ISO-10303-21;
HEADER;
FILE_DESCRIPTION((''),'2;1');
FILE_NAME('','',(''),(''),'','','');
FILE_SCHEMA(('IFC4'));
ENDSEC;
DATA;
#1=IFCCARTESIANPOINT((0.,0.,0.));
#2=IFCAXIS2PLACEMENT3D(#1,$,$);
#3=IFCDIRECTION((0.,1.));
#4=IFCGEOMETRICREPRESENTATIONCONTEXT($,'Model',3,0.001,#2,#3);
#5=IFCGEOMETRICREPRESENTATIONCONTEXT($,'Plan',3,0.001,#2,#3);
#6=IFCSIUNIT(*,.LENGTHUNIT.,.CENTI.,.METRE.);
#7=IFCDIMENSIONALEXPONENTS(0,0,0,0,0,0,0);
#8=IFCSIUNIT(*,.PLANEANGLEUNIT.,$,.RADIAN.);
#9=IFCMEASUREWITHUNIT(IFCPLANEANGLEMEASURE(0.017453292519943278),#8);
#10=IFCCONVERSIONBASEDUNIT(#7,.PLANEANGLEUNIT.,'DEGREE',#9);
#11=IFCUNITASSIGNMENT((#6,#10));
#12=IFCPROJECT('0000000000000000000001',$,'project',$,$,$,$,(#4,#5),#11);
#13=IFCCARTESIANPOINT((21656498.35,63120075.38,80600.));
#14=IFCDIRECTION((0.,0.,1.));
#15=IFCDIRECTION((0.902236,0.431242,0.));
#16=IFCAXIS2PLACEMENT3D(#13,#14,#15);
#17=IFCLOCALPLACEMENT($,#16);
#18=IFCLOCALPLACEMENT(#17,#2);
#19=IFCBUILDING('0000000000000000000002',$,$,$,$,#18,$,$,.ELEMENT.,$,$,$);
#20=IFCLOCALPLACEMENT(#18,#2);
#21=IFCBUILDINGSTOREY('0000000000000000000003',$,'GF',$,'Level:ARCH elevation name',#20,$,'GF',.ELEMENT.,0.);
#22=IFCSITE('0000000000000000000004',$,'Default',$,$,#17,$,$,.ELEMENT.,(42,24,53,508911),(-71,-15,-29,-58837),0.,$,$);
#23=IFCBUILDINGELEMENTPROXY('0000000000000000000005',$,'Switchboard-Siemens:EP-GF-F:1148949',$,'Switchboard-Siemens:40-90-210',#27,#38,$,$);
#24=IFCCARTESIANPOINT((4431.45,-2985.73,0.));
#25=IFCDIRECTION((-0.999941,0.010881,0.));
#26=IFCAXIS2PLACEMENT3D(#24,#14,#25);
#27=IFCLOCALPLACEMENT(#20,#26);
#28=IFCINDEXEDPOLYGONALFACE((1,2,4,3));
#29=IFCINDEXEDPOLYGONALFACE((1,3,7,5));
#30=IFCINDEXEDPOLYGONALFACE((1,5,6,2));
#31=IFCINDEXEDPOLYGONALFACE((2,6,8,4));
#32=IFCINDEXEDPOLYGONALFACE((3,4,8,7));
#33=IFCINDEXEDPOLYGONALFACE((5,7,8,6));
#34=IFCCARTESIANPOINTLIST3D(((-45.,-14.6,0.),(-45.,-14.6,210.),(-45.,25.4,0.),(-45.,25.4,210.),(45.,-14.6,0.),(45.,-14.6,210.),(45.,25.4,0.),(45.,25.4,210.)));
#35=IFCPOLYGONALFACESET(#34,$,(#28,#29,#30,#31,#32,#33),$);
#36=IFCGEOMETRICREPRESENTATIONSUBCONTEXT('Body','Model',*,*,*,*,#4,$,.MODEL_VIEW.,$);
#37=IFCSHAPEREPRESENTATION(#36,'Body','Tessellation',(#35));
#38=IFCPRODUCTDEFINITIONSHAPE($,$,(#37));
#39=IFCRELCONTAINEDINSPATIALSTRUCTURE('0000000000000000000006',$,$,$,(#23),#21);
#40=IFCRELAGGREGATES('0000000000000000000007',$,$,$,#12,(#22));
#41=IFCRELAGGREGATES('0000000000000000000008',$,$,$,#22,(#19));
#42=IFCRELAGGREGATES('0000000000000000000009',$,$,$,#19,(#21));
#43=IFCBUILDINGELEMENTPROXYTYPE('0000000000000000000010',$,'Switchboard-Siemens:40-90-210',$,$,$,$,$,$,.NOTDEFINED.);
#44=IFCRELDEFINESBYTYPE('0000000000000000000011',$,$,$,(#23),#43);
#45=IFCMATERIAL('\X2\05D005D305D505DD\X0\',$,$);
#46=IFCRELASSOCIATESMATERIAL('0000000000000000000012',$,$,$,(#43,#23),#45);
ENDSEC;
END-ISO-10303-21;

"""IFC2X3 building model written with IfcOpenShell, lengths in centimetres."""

from ifc_helpers import new_model, entity, si_unit, converted_unit, direction, frame, origin, origin_2d_with_axis, place, context, subcontext, project, spatial, rectangle, extrude, source, transform, mapped, material, type_object, type_shapes, element, save


model = new_model("IFC2X3")

# Units and contexts
model_context = context("Model", 3, precision=0.001, world=origin(), true_north=direction((0.0, 1.0)))
plan_context = context("Plan", 3, precision=0.001, world=origin(), true_north=direction((0.0, 1.0)))
body_context = subcontext(model_context, "Body", "Model", "MODEL_VIEW")
ifc_project = project(units=[si_unit("LENGTHUNIT", "METRE", prefix="CENTI"), converted_unit("PLANEANGLEUNIT", "DEGREE", entity("IfcPlaneAngleMeasure", 0.017453292519943278), si_unit("PLANEANGLEUNIT", "RADIAN"), dimensions=[0, 0, 0, 0, 0, 0, 0])], contexts=[model_context, plan_context])

# Site, building, storey
site_placement = place(None, frame((21656498.35, 63120075.38, 80600.0), z_axis=(0.0, 0.0, 1.0), x_axis=(0.902236, 0.431242, 0.0)))
site = spatial("IfcSite", under=ifc_project, at=site_placement, Name="Default", CompositionType="ELEMENT", RefLatitude=(42, 24, 53, 508911), RefLongitude=(-71, -15, -29, -58837), RefElevation=0.0)
building_placement = place(site_placement, origin())
building = spatial("IfcBuilding", under=site, at=building_placement, CompositionType="ELEMENT")
storey_placement = place(building_placement, origin())
storey = spatial("IfcBuildingStorey", under=building, at=storey_placement, Name="GF", ObjectType="Level:ARCH elevation name", LongName="GF", CompositionType="ELEMENT", Elevation=0.0)

# Building element proxy
ifc_material_1 = material(Name="אדום")
building_element_proxy_type_1 = type_object("IfcBuildingElementProxyType", Name="Switchboard-Siemens:40-90-210", PredefinedType="NOTDEFINED", material=ifc_material_1)
shared_shape_1 = source(origin(), body_context, "Body", "SweptSolid", [
    extrude(rectangle(XDim=90.0, YDim=40.0, at=origin_2d_with_axis()), frame((0.0, 5.4, 0.0), z_axis=(0.0, 0.0, 1.0), x_axis=(-1.0, 0.0, 0.0)), (0.0, 0.0, 1.0), 210.0),
])
type_shapes(building_element_proxy_type_1, [shared_shape_1])
proxy_1_placement = place(storey_placement, frame((4431.45, -2985.73, 0.0), z_axis=(0.0, 0.0, 1.0), x_axis=(-0.999941, 0.010881, 0.0)))
element("IfcBuildingElementProxy", 1, at=proxy_1_placement, inside=storey, type_object=building_element_proxy_type_1, material=ifc_material_1, Name="Switchboard-Siemens:EP-GF-F:1148949", ObjectType="Switchboard-Siemens:40-90-210", context=body_context, shape_type="MappedRepresentation", body=[
    mapped(shared_shape_1, transform((0.0, 0.0, 0.0), scale=1.0)),
])

save(model, "model.ifc")
